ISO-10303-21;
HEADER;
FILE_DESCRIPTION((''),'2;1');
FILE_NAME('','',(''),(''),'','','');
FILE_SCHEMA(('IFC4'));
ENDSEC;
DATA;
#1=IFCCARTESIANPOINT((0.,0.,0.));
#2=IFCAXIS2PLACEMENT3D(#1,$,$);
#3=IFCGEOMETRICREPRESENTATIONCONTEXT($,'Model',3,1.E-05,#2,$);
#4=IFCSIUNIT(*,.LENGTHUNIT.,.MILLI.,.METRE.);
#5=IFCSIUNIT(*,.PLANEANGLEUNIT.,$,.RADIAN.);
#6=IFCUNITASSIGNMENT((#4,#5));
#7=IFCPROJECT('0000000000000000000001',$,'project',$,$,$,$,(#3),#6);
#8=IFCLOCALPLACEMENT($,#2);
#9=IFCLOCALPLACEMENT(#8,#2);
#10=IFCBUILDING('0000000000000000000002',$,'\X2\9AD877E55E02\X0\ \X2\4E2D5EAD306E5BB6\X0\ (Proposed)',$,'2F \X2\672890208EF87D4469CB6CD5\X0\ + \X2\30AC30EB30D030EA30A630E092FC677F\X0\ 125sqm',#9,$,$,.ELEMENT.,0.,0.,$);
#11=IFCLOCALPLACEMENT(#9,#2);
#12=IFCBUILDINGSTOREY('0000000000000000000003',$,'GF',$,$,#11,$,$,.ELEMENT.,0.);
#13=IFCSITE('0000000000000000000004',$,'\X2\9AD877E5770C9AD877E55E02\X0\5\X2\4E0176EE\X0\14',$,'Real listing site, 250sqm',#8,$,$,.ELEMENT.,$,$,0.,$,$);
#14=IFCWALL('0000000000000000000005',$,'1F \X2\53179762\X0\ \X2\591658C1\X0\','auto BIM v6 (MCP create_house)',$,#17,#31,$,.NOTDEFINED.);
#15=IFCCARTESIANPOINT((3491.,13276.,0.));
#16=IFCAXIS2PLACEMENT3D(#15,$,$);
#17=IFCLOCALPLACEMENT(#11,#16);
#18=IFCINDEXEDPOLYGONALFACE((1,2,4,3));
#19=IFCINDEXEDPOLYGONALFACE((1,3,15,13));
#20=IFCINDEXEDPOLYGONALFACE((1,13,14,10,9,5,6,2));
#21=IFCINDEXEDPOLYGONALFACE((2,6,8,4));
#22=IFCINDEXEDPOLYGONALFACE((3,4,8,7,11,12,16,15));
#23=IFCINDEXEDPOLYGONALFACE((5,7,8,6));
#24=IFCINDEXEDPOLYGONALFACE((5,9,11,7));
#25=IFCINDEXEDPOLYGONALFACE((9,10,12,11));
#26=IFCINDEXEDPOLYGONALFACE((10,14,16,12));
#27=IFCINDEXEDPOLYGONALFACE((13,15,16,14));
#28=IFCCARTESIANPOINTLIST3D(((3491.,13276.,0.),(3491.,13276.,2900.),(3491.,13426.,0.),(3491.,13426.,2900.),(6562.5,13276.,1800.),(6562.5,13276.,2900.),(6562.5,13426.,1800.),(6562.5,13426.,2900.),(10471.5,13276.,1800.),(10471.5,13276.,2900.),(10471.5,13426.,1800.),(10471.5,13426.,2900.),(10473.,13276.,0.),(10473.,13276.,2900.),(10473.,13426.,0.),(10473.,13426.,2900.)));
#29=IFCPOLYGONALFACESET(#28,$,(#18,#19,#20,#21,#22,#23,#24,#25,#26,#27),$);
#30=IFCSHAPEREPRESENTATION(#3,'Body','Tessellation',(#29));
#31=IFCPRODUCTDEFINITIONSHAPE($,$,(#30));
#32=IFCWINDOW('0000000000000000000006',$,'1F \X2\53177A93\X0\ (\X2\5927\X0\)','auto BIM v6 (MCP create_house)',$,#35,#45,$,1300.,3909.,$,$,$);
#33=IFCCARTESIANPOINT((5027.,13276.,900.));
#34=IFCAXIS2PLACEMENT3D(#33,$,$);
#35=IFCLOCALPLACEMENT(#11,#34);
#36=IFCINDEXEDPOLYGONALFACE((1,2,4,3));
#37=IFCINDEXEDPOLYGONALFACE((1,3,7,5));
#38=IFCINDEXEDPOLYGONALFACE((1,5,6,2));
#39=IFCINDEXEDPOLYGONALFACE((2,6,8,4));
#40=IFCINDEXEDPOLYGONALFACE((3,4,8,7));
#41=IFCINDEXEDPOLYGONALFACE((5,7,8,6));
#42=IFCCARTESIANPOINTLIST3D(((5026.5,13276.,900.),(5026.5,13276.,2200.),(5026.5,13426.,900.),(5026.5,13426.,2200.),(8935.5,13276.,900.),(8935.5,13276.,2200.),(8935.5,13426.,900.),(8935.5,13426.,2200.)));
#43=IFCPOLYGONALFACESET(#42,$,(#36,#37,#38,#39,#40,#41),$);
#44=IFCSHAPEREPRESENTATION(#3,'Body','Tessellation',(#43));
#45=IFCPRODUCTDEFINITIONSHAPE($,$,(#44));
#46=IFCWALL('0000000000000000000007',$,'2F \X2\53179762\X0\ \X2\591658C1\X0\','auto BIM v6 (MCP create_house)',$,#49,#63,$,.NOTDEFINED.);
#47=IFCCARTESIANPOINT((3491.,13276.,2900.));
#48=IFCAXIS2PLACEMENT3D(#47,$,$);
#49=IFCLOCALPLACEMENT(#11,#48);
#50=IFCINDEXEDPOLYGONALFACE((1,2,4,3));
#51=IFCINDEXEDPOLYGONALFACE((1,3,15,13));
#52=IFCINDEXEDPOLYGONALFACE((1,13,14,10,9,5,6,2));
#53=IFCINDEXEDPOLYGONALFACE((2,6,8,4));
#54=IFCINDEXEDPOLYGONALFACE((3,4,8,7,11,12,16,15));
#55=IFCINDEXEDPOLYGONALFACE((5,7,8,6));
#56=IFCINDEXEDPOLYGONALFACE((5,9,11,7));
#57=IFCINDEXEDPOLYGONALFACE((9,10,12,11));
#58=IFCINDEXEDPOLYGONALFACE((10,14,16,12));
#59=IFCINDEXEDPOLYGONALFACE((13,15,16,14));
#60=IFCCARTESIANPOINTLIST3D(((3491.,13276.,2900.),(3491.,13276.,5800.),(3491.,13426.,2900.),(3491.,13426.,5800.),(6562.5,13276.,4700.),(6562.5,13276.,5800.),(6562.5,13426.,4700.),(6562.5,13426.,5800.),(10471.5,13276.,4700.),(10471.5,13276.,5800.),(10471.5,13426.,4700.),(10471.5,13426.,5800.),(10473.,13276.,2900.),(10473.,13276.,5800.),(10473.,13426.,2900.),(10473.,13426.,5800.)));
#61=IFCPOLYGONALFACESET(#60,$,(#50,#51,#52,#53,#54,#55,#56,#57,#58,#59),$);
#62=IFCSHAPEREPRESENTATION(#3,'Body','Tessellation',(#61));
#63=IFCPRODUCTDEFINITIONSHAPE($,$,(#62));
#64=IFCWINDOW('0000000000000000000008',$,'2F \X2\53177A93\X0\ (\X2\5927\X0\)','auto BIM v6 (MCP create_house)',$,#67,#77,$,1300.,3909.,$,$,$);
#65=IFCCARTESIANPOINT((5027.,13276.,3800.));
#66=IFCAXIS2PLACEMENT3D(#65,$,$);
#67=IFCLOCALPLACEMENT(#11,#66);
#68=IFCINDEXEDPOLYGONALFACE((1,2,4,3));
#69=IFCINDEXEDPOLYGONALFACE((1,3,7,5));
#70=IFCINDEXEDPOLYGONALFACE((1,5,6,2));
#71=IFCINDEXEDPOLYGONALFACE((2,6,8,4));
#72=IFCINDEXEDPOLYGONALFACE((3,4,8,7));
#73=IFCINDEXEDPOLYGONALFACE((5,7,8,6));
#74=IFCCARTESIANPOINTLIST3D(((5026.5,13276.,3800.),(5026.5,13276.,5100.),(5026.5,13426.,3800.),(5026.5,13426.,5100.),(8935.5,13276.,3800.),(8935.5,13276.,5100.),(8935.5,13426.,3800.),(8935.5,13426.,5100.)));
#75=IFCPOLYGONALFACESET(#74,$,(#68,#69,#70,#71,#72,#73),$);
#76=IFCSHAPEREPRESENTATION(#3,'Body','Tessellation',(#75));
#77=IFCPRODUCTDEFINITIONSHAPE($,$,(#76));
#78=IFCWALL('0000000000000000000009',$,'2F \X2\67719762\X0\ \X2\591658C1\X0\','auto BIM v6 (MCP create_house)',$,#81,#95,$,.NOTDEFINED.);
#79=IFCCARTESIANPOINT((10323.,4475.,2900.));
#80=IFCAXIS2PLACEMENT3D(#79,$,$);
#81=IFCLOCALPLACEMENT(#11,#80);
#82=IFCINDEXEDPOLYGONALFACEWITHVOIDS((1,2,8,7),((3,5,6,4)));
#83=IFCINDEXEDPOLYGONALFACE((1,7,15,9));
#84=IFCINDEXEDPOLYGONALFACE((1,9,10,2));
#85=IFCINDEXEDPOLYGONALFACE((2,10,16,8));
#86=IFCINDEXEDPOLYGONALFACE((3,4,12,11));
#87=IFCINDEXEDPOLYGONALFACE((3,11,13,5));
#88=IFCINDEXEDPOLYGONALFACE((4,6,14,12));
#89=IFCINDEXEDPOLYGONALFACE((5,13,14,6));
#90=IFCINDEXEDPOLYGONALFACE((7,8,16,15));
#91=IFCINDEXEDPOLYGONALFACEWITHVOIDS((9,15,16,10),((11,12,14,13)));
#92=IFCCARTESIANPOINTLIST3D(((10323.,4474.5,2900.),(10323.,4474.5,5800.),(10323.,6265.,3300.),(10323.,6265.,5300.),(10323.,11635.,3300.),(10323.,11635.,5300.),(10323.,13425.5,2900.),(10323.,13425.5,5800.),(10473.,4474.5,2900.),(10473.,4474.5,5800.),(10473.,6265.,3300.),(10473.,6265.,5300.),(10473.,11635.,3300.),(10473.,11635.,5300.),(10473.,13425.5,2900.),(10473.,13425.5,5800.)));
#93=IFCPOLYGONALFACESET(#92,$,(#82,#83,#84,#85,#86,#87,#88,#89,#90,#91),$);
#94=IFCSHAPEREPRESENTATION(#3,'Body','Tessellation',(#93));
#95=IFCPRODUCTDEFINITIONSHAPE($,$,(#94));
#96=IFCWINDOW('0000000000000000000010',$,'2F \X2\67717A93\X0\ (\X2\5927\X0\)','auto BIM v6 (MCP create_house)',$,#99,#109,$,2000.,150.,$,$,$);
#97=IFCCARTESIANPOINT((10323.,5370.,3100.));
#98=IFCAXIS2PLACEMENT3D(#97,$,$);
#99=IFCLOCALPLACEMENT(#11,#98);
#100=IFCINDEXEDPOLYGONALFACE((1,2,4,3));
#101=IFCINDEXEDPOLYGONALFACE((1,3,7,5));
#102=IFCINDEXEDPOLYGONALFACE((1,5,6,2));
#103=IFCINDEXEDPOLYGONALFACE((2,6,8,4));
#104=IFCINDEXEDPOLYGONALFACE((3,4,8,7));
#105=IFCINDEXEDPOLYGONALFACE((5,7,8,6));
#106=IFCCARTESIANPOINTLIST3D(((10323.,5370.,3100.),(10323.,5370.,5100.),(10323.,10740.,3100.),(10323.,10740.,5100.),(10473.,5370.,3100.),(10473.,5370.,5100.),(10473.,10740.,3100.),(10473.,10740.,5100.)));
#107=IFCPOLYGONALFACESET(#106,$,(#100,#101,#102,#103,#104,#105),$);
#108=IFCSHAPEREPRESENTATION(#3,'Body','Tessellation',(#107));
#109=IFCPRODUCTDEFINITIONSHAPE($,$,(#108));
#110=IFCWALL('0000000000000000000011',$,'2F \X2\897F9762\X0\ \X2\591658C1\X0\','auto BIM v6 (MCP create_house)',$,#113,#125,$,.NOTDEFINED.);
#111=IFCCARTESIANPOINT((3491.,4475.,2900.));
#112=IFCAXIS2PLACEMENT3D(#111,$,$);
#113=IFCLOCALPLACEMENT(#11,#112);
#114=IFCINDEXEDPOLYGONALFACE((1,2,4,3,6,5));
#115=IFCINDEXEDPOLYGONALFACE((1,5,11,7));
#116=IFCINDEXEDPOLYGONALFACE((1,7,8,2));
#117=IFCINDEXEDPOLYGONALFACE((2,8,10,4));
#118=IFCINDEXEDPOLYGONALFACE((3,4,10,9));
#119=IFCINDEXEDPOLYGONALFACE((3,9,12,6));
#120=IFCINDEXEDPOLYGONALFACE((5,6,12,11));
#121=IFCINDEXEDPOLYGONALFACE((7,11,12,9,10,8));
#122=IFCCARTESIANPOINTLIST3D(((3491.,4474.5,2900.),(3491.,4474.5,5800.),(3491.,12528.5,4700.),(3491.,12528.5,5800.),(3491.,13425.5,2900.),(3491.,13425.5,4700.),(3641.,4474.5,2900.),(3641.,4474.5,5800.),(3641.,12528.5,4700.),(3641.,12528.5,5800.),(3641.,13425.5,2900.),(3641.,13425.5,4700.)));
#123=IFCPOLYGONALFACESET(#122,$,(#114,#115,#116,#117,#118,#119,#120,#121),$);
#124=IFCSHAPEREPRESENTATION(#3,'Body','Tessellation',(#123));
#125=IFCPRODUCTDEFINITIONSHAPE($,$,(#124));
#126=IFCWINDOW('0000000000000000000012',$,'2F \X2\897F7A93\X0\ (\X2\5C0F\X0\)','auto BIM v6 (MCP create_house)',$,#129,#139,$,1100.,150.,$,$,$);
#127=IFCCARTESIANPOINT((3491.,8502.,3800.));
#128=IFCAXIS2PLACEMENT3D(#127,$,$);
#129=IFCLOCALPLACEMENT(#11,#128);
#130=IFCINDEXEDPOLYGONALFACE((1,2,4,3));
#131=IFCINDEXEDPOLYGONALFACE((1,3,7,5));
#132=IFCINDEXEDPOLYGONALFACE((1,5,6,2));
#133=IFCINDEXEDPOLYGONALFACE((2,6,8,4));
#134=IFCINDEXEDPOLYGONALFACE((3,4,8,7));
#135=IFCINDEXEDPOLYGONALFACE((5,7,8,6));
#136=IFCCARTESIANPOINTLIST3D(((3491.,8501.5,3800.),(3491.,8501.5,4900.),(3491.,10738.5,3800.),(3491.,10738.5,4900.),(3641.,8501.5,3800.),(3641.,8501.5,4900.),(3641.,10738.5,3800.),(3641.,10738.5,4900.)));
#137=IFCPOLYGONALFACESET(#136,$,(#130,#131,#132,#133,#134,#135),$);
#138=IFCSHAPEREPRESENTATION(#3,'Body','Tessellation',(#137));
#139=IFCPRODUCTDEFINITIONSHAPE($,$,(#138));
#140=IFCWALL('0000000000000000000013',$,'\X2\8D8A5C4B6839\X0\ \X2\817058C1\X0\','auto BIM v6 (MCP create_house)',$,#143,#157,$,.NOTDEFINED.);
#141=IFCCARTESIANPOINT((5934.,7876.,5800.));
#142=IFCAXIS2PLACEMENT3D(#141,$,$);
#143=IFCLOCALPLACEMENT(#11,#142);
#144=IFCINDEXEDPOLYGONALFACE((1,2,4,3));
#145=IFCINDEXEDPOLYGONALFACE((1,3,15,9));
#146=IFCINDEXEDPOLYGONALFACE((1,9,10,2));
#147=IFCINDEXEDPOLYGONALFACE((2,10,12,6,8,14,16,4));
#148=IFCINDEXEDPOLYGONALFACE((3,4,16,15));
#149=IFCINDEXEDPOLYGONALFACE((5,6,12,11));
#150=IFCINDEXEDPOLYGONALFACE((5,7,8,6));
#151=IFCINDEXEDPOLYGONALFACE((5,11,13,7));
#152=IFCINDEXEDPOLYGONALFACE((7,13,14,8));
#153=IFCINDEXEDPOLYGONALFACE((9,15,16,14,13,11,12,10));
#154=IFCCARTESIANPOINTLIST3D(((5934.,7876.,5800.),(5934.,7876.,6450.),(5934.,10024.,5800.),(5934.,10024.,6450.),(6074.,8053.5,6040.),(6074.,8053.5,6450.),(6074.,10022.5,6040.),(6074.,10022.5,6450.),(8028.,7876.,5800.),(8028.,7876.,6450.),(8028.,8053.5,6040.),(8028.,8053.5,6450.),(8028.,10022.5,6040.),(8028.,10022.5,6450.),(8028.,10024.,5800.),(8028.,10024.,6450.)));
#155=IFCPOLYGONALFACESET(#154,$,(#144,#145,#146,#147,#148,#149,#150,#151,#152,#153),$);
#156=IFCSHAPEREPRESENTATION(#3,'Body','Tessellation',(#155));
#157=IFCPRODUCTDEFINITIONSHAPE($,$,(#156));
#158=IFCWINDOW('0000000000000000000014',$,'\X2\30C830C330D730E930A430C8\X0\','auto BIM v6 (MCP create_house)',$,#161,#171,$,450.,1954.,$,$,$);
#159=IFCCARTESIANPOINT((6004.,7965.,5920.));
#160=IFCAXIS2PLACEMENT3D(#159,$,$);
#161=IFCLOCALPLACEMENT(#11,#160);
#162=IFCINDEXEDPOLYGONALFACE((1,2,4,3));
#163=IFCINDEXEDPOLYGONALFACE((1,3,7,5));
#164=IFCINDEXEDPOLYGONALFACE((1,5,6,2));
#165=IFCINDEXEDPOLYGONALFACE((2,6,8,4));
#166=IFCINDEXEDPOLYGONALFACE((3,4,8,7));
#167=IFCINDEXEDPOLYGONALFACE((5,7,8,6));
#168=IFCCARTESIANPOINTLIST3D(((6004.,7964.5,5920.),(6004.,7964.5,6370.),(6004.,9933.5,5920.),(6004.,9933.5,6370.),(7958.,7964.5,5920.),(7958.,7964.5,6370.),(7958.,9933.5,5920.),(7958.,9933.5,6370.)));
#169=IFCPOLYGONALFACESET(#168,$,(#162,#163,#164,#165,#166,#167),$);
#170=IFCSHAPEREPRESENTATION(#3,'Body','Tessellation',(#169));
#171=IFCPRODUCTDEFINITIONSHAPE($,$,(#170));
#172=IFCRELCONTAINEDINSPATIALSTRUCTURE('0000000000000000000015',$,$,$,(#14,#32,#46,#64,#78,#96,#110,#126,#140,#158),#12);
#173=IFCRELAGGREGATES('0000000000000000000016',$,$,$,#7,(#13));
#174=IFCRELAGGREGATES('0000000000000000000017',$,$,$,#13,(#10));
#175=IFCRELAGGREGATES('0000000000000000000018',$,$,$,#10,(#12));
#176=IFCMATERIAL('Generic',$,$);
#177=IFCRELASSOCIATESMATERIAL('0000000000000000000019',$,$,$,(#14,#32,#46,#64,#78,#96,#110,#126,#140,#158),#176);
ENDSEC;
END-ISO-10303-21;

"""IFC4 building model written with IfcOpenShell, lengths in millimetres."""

from ifc_helpers import new_model, si_unit, frame, frame_2d, origin, place, context, project, spatial, rectangle, extrude, material, element, fill, save


model = new_model("IFC4")

# Units and contexts
model_context = context("Model", 3, precision=1e-05, world=origin())
ifc_project = project(units=[si_unit("LENGTHUNIT", "METRE", prefix="MILLI"), si_unit("PLANEANGLEUNIT", "RADIAN")], contexts=[model_context])

# Site, building, storey
site_placement = place(None, origin())
site = spatial("IfcSite", under=ifc_project, at=site_placement, Name="高知県高知市5丁目14", ObjectType="Real listing site, 250sqm", CompositionType="ELEMENT", RefElevation=0.0)
building_placement = place(site_placement, origin())
building = spatial("IfcBuilding", under=site, at=building_placement, Name="高知市 中庭の家 (Proposed)", ObjectType="2F 木造軸組構法 + ガルバリウム鋼板 125sqm", CompositionType="ELEMENT", ElevationOfRefHeight=0.0, ElevationOfTerrain=0.0)
storey_placement = place(building_placement, origin())
storey = spatial("IfcBuildingStorey", under=building, at=storey_placement, Name="GF", CompositionType="ELEMENT", Elevation=0.0)

# Wall, opening, window
ifc_material = material(Name="Generic")
wall_1_placement = place(storey_placement, frame((3491.0, 13276.0, 0.0)))
wall_1 = element("IfcWall", 1, at=wall_1_placement, inside=storey, material=ifc_material, Name="1F 北面 外壁", Description="auto BIM v6 (MCP create_house)", PredefinedType="NOTDEFINED", context=model_context, shape_type="SweptSolid", body=[
    extrude(rectangle(XDim=6982.0, YDim=150.0, at=frame_2d((3491.0, 75.0))), frame((3491.0, 13276.0, 0.0)), (0.0, 0.0, 1.0), 2900.0),
])
opening_1_placement = place(storey_placement, frame((5027.0, 13276.0, 900.0)))
opening_1 = element("IfcOpeningElement", 2, at=opening_1_placement, cuts=wall_1, PredefinedType="NOTDEFINED", context=model_context, shape_type="SweptSolid", body=[
    extrude(rectangle(XDim=3909.0, YDim=150.0, at=frame_2d((1954.0, 75.0))), frame((5027.0, 13276.0, 900.0)), (0.0, 0.0, 1.0), 1300.0),
])
window_1_placement = place(storey_placement, frame((5027.0, 13276.0, 900.0)))
window_1 = element("IfcWindow", 3, at=window_1_placement, inside=storey, material=ifc_material, Name="1F 北窓 (大)", Description="auto BIM v6 (MCP create_house)", OverallHeight=1300.0, OverallWidth=3909.0, context=model_context, shape_type="SweptSolid", body=[
    extrude(rectangle(XDim=3909.0, YDim=150.0, at=frame_2d((1954.0, 75.0))), frame((5027.0, 13276.0, 900.0)), (0.0, 0.0, 1.0), 1300.0),
])
fill(opening_1, window_1)

# Walls, openings, windows
wall_2_placement = place(storey_placement, frame((3491.0, 13276.0, 2900.0)))
wall_2 = element("IfcWall", 4, at=wall_2_placement, inside=storey, material=ifc_material, Name="2F 北面 外壁", Description="auto BIM v6 (MCP create_house)", PredefinedType="NOTDEFINED", context=model_context, shape_type="SweptSolid", body=[
    extrude(rectangle(XDim=6982.0, YDim=150.0, at=frame_2d((3491.0, 75.0))), frame((3491.0, 13276.0, 2900.0)), (0.0, 0.0, 1.0), 2900.0),
])
opening_2_placement = place(storey_placement, frame((5027.0, 13276.0, 3800.0)))
opening_2 = element("IfcOpeningElement", 5, at=opening_2_placement, cuts=wall_2, PredefinedType="NOTDEFINED", context=model_context, shape_type="SweptSolid", body=[
    extrude(rectangle(XDim=3909.0, YDim=150.0, at=frame_2d((1954.0, 75.0))), frame((5027.0, 13276.0, 3800.0)), (0.0, 0.0, 1.0), 1300.0),
])
window_2_placement = place(storey_placement, frame((5027.0, 13276.0, 3800.0)))
window_2 = element("IfcWindow", 6, at=window_2_placement, inside=storey, material=ifc_material, Name="2F 北窓 (大)", Description="auto BIM v6 (MCP create_house)", OverallHeight=1300.0, OverallWidth=3909.0, context=model_context, shape_type="SweptSolid", body=[
    extrude(rectangle(XDim=3909.0, YDim=150.0, at=frame_2d((1954.0, 75.0))), frame((5027.0, 13276.0, 3800.0)), (0.0, 0.0, 1.0), 1300.0),
])
fill(opening_2, window_2)
wall_3_placement = place(storey_placement, frame((10323.0, 4475.0, 2900.0)))
wall_3 = element("IfcWall", 7, at=wall_3_placement, inside=storey, material=ifc_material, Name="2F 東面 外壁", Description="auto BIM v6 (MCP create_house)", PredefinedType="NOTDEFINED", context=model_context, shape_type="SweptSolid", body=[
    extrude(rectangle(XDim=150.0, YDim=8951.0, at=frame_2d((75.0, 4475.0))), frame((10323.0, 4475.0, 2900.0)), (0.0, 0.0, 1.0), 2900.0),
])
opening_3_placement = place(storey_placement, frame((10323.0, 5370.0, 3100.0)))
opening_3 = element("IfcOpeningElement", 8, at=opening_3_placement, cuts=wall_3, PredefinedType="NOTDEFINED", context=model_context, shape_type="SweptSolid", body=[
    extrude(rectangle(XDim=150.0, YDim=5370.0, at=frame_2d((75.0, 2685.0))), frame((10323.0, 5370.0, 3100.0)), (0.0, 0.0, 1.0), 2000.0),
])
window_3_placement = place(storey_placement, frame((10323.0, 5370.0, 3100.0)))
window_3 = element("IfcWindow", 9, at=window_3_placement, inside=storey, material=ifc_material, Name="2F 東窓 (大)", Description="auto BIM v6 (MCP create_house)", OverallHeight=2000.0, OverallWidth=150.0, context=model_context, shape_type="SweptSolid", body=[
    extrude(rectangle(XDim=150.0, YDim=5370.0, at=frame_2d((75.0, 2685.0))), frame((10323.0, 5370.0, 3100.0)), (0.0, 0.0, 1.0), 2000.0),
])
fill(opening_3, window_3)
wall_4_placement = place(storey_placement, frame((3491.0, 4475.0, 2900.0)))
wall_4 = element("IfcWall", 10, at=wall_4_placement, inside=storey, material=ifc_material, Name="2F 西面 外壁", Description="auto BIM v6 (MCP create_house)", PredefinedType="NOTDEFINED", context=model_context, shape_type="SweptSolid", body=[
    extrude(rectangle(XDim=150.0, YDim=8951.0, at=frame_2d((75.0, 4475.0))), frame((3491.0, 4475.0, 2900.0)), (0.0, 0.0, 1.0), 2900.0),
])
opening_4_placement = place(storey_placement, frame((3491.0, 8502.0, 3800.0)))
opening_4 = element("IfcOpeningElement", 11, at=opening_4_placement, cuts=wall_4, PredefinedType="NOTDEFINED", context=model_context, shape_type="SweptSolid", body=[
    extrude(rectangle(XDim=150.0, YDim=2237.0, at=frame_2d((75.0, 1118.0))), frame((3491.0, 8502.0, 3800.0)), (0.0, 0.0, 1.0), 1100.0),
])
window_4_placement = place(storey_placement, frame((3491.0, 8502.0, 3800.0)))
window_4 = element("IfcWindow", 12, at=window_4_placement, inside=storey, material=ifc_material, Name="2F 西窓 (小)", Description="auto BIM v6 (MCP create_house)", OverallHeight=1100.0, OverallWidth=150.0, context=model_context, shape_type="SweptSolid", body=[
    extrude(rectangle(XDim=150.0, YDim=2237.0, at=frame_2d((75.0, 1118.0))), frame((3491.0, 8502.0, 3800.0)), (0.0, 0.0, 1.0), 1100.0),
])
fill(opening_4, window_4)

# Wall, opening, window
wall_5_placement = place(storey_placement, frame((5934.0, 7876.0, 5800.0)))
wall_5 = element("IfcWall", 13, at=wall_5_placement, inside=storey, material=ifc_material, Name="越屋根 腰壁", Description="auto BIM v6 (MCP create_house)", PredefinedType="NOTDEFINED", context=model_context, shape_type="SweptSolid", body=[
    extrude(rectangle(XDim=2094.0, YDim=2148.0, at=frame_2d((1047.0, 1074.0))), frame((5934.0, 7876.0, 5800.0)), (0.0, 0.0, 1.0), 650.0),
])
opening_5_placement = place(storey_placement, frame((6004.0, 7965.0, 5920.0)))
opening_5 = element("IfcOpeningElement", 14, at=opening_5_placement, cuts=wall_5, PredefinedType="NOTDEFINED", context=model_context, shape_type="SweptSolid", body=[
    extrude(rectangle(XDim=1954.0, YDim=1969.0, at=frame_2d((977.0, 984.0))), frame((6004.0, 7965.0, 5920.0)), (0.0, 0.0, 1.0), 450.0),
])
window_5_placement = place(storey_placement, frame((6004.0, 7965.0, 5920.0)))
window_5 = element("IfcWindow", 15, at=window_5_placement, inside=storey, material=ifc_material, Name="トップライト", Description="auto BIM v6 (MCP create_house)", OverallHeight=450.0, OverallWidth=1954.0, context=model_context, shape_type="SweptSolid", body=[
    extrude(rectangle(XDim=1954.0, YDim=1969.0, at=frame_2d((977.0, 984.0))), frame((6004.0, 7965.0, 5920.0)), (0.0, 0.0, 1.0), 450.0),
])
fill(opening_5, window_5)

save(model, "model.ifc")
